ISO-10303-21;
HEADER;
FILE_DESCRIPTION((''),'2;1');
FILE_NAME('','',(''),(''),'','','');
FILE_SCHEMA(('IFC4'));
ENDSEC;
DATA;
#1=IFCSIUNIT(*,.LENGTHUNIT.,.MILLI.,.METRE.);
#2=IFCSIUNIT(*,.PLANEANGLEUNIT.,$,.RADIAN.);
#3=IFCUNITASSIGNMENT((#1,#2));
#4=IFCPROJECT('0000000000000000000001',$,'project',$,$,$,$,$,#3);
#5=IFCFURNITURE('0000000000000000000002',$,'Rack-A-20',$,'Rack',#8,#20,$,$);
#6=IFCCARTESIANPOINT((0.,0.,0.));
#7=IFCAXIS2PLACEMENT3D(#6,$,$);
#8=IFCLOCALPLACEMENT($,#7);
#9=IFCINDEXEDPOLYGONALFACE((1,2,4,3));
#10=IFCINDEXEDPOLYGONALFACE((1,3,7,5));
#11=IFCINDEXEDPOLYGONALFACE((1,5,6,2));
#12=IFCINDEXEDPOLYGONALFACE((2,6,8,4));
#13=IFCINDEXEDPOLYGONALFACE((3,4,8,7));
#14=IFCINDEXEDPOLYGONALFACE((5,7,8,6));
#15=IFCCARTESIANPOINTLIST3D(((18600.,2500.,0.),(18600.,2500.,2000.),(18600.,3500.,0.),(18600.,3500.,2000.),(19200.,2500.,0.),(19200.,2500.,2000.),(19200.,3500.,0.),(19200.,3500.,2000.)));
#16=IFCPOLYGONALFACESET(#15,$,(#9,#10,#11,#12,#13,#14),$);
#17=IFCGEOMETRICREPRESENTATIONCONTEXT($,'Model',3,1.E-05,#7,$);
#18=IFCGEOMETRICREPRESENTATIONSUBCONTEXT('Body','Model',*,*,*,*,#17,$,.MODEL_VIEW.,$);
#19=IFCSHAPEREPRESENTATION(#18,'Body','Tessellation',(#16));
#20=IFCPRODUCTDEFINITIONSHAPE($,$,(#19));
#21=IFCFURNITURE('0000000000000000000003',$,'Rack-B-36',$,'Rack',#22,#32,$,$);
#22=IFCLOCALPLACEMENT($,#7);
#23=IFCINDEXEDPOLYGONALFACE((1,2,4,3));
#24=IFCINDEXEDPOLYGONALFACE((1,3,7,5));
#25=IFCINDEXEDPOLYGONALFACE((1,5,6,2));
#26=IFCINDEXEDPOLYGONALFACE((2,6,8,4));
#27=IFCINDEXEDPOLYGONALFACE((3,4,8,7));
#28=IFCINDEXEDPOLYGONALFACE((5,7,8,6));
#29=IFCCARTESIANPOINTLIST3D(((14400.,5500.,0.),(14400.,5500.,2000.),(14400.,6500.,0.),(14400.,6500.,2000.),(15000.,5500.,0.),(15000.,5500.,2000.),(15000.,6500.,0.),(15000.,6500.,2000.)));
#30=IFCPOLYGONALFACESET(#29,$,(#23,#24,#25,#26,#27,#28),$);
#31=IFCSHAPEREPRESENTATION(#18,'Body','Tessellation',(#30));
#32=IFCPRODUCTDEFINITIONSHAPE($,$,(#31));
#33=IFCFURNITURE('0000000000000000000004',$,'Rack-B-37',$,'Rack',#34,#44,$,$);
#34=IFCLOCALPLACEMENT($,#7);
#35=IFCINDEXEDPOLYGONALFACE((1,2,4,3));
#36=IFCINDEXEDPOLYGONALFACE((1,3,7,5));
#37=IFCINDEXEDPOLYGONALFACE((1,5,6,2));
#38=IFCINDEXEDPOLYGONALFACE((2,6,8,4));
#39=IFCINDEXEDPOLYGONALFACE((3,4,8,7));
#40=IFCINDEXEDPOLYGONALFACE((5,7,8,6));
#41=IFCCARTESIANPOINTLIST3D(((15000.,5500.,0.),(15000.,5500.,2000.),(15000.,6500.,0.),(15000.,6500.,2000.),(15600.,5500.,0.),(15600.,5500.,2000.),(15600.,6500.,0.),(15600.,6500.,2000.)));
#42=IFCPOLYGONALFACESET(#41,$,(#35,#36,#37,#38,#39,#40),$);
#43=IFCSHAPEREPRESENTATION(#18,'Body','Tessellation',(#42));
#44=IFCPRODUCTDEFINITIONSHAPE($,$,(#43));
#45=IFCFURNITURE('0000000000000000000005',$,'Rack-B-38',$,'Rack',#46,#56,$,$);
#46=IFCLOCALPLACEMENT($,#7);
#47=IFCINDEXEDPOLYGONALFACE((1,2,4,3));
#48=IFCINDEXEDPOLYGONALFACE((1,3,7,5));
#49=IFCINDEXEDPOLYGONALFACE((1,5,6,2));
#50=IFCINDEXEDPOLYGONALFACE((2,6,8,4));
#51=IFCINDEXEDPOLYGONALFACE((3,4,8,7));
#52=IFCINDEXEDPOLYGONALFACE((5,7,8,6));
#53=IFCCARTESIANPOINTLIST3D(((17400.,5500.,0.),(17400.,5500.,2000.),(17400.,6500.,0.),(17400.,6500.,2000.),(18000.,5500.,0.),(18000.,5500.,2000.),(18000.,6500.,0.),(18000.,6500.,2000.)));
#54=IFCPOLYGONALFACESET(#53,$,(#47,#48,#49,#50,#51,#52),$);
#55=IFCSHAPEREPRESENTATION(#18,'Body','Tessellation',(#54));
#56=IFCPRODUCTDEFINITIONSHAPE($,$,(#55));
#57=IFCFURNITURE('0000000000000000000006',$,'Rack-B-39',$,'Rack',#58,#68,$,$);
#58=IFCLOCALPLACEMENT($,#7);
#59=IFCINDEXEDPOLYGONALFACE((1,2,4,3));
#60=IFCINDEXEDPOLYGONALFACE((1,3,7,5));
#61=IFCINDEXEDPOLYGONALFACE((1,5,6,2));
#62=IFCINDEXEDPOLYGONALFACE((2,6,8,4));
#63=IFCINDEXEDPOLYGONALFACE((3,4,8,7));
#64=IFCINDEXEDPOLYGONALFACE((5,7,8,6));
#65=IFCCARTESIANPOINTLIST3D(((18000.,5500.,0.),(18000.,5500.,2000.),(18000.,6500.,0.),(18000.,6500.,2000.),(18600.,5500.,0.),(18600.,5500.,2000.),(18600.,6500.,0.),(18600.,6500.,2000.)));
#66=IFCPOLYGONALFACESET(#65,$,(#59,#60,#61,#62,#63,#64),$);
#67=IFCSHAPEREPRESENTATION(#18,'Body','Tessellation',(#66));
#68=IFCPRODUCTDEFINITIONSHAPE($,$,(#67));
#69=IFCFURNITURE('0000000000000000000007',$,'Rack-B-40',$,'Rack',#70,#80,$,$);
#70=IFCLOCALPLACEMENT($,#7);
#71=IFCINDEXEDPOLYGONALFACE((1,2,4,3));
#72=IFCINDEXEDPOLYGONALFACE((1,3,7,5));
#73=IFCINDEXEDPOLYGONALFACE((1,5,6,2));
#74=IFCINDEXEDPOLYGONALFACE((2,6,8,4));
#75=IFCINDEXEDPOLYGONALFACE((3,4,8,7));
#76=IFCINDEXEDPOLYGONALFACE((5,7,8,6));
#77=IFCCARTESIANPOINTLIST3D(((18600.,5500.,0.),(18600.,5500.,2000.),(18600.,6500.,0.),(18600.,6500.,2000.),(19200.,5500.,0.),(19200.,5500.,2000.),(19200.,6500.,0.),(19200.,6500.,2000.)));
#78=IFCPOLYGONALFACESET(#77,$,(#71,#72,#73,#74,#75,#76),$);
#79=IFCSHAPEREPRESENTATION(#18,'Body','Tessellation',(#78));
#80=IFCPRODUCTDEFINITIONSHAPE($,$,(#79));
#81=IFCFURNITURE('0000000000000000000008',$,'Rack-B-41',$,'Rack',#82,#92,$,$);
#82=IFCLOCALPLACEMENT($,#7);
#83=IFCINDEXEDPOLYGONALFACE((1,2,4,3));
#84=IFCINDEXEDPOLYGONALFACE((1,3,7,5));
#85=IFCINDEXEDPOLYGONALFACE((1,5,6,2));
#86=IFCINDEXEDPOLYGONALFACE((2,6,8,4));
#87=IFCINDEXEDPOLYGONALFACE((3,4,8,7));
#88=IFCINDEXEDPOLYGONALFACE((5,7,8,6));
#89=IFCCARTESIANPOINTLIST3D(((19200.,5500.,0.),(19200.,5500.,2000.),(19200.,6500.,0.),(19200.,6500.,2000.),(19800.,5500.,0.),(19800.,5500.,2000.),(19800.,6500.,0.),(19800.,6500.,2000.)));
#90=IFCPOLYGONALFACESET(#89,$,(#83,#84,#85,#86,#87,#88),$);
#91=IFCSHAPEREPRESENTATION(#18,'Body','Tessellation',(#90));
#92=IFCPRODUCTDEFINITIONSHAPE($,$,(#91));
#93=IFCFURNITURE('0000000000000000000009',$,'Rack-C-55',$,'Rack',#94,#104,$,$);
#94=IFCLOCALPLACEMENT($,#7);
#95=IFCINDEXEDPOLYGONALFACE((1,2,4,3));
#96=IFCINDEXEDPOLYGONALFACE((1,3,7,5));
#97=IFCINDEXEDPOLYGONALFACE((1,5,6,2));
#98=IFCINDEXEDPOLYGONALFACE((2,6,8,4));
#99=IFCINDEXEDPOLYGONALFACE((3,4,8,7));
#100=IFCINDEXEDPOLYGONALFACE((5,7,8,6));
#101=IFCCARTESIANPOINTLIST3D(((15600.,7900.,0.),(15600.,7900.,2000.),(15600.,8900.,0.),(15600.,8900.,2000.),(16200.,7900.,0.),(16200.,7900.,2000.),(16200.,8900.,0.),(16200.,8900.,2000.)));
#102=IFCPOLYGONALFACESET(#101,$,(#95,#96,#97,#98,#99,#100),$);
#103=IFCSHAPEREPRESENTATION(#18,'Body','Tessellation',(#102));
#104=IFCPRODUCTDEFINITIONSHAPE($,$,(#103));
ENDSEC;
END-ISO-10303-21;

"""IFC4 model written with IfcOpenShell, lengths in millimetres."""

from ifc_helpers import new_model, si_unit, frame, origin, place, context, subcontext, project, rectangle, extrude, element, save


model = new_model("IFC4")

# Units and contexts
model_context = context("Model", 3, precision=1e-05, world=origin())
body_context = subcontext(model_context, "Body", "Model", "MODEL_VIEW")
ifc_project = project(units=[si_unit("LENGTHUNIT", "METRE", prefix="MILLI"), si_unit("PLANEANGLEUNIT", "RADIAN")])

# Furniture
for number, where, name in (
    (1, (18900.0, 3000.0, 0.0), "Rack-A-20"),
    (2, (14700.0, 6000.0, 0.0), "Rack-B-36"),
    (3, (15300.0, 6000.0, 0.0), "Rack-B-37"),
    (4, (17700.0, 6000.0, 0.0), "Rack-B-38"),
    (5, (18300.0, 6000.0, 0.0), "Rack-B-39"),
    (6, (18900.0, 6000.0, 0.0), "Rack-B-40"),
    (7, (19500.0, 6000.0, 0.0), "Rack-B-41"),
    (8, (15900.0, 8400.0, 0.0), "Rack-C-55"),
):
    element("IfcFurniture", number, at=place(None, frame(where)), Name=name, ObjectType="Rack", context=body_context, shape_type="SweptSolid", body=[
        extrude(rectangle(XDim=600.0, YDim=1000.0), None, (0.0, 0.0, 1.0), 2000.0),
    ])

save(model, "model.ifc")
